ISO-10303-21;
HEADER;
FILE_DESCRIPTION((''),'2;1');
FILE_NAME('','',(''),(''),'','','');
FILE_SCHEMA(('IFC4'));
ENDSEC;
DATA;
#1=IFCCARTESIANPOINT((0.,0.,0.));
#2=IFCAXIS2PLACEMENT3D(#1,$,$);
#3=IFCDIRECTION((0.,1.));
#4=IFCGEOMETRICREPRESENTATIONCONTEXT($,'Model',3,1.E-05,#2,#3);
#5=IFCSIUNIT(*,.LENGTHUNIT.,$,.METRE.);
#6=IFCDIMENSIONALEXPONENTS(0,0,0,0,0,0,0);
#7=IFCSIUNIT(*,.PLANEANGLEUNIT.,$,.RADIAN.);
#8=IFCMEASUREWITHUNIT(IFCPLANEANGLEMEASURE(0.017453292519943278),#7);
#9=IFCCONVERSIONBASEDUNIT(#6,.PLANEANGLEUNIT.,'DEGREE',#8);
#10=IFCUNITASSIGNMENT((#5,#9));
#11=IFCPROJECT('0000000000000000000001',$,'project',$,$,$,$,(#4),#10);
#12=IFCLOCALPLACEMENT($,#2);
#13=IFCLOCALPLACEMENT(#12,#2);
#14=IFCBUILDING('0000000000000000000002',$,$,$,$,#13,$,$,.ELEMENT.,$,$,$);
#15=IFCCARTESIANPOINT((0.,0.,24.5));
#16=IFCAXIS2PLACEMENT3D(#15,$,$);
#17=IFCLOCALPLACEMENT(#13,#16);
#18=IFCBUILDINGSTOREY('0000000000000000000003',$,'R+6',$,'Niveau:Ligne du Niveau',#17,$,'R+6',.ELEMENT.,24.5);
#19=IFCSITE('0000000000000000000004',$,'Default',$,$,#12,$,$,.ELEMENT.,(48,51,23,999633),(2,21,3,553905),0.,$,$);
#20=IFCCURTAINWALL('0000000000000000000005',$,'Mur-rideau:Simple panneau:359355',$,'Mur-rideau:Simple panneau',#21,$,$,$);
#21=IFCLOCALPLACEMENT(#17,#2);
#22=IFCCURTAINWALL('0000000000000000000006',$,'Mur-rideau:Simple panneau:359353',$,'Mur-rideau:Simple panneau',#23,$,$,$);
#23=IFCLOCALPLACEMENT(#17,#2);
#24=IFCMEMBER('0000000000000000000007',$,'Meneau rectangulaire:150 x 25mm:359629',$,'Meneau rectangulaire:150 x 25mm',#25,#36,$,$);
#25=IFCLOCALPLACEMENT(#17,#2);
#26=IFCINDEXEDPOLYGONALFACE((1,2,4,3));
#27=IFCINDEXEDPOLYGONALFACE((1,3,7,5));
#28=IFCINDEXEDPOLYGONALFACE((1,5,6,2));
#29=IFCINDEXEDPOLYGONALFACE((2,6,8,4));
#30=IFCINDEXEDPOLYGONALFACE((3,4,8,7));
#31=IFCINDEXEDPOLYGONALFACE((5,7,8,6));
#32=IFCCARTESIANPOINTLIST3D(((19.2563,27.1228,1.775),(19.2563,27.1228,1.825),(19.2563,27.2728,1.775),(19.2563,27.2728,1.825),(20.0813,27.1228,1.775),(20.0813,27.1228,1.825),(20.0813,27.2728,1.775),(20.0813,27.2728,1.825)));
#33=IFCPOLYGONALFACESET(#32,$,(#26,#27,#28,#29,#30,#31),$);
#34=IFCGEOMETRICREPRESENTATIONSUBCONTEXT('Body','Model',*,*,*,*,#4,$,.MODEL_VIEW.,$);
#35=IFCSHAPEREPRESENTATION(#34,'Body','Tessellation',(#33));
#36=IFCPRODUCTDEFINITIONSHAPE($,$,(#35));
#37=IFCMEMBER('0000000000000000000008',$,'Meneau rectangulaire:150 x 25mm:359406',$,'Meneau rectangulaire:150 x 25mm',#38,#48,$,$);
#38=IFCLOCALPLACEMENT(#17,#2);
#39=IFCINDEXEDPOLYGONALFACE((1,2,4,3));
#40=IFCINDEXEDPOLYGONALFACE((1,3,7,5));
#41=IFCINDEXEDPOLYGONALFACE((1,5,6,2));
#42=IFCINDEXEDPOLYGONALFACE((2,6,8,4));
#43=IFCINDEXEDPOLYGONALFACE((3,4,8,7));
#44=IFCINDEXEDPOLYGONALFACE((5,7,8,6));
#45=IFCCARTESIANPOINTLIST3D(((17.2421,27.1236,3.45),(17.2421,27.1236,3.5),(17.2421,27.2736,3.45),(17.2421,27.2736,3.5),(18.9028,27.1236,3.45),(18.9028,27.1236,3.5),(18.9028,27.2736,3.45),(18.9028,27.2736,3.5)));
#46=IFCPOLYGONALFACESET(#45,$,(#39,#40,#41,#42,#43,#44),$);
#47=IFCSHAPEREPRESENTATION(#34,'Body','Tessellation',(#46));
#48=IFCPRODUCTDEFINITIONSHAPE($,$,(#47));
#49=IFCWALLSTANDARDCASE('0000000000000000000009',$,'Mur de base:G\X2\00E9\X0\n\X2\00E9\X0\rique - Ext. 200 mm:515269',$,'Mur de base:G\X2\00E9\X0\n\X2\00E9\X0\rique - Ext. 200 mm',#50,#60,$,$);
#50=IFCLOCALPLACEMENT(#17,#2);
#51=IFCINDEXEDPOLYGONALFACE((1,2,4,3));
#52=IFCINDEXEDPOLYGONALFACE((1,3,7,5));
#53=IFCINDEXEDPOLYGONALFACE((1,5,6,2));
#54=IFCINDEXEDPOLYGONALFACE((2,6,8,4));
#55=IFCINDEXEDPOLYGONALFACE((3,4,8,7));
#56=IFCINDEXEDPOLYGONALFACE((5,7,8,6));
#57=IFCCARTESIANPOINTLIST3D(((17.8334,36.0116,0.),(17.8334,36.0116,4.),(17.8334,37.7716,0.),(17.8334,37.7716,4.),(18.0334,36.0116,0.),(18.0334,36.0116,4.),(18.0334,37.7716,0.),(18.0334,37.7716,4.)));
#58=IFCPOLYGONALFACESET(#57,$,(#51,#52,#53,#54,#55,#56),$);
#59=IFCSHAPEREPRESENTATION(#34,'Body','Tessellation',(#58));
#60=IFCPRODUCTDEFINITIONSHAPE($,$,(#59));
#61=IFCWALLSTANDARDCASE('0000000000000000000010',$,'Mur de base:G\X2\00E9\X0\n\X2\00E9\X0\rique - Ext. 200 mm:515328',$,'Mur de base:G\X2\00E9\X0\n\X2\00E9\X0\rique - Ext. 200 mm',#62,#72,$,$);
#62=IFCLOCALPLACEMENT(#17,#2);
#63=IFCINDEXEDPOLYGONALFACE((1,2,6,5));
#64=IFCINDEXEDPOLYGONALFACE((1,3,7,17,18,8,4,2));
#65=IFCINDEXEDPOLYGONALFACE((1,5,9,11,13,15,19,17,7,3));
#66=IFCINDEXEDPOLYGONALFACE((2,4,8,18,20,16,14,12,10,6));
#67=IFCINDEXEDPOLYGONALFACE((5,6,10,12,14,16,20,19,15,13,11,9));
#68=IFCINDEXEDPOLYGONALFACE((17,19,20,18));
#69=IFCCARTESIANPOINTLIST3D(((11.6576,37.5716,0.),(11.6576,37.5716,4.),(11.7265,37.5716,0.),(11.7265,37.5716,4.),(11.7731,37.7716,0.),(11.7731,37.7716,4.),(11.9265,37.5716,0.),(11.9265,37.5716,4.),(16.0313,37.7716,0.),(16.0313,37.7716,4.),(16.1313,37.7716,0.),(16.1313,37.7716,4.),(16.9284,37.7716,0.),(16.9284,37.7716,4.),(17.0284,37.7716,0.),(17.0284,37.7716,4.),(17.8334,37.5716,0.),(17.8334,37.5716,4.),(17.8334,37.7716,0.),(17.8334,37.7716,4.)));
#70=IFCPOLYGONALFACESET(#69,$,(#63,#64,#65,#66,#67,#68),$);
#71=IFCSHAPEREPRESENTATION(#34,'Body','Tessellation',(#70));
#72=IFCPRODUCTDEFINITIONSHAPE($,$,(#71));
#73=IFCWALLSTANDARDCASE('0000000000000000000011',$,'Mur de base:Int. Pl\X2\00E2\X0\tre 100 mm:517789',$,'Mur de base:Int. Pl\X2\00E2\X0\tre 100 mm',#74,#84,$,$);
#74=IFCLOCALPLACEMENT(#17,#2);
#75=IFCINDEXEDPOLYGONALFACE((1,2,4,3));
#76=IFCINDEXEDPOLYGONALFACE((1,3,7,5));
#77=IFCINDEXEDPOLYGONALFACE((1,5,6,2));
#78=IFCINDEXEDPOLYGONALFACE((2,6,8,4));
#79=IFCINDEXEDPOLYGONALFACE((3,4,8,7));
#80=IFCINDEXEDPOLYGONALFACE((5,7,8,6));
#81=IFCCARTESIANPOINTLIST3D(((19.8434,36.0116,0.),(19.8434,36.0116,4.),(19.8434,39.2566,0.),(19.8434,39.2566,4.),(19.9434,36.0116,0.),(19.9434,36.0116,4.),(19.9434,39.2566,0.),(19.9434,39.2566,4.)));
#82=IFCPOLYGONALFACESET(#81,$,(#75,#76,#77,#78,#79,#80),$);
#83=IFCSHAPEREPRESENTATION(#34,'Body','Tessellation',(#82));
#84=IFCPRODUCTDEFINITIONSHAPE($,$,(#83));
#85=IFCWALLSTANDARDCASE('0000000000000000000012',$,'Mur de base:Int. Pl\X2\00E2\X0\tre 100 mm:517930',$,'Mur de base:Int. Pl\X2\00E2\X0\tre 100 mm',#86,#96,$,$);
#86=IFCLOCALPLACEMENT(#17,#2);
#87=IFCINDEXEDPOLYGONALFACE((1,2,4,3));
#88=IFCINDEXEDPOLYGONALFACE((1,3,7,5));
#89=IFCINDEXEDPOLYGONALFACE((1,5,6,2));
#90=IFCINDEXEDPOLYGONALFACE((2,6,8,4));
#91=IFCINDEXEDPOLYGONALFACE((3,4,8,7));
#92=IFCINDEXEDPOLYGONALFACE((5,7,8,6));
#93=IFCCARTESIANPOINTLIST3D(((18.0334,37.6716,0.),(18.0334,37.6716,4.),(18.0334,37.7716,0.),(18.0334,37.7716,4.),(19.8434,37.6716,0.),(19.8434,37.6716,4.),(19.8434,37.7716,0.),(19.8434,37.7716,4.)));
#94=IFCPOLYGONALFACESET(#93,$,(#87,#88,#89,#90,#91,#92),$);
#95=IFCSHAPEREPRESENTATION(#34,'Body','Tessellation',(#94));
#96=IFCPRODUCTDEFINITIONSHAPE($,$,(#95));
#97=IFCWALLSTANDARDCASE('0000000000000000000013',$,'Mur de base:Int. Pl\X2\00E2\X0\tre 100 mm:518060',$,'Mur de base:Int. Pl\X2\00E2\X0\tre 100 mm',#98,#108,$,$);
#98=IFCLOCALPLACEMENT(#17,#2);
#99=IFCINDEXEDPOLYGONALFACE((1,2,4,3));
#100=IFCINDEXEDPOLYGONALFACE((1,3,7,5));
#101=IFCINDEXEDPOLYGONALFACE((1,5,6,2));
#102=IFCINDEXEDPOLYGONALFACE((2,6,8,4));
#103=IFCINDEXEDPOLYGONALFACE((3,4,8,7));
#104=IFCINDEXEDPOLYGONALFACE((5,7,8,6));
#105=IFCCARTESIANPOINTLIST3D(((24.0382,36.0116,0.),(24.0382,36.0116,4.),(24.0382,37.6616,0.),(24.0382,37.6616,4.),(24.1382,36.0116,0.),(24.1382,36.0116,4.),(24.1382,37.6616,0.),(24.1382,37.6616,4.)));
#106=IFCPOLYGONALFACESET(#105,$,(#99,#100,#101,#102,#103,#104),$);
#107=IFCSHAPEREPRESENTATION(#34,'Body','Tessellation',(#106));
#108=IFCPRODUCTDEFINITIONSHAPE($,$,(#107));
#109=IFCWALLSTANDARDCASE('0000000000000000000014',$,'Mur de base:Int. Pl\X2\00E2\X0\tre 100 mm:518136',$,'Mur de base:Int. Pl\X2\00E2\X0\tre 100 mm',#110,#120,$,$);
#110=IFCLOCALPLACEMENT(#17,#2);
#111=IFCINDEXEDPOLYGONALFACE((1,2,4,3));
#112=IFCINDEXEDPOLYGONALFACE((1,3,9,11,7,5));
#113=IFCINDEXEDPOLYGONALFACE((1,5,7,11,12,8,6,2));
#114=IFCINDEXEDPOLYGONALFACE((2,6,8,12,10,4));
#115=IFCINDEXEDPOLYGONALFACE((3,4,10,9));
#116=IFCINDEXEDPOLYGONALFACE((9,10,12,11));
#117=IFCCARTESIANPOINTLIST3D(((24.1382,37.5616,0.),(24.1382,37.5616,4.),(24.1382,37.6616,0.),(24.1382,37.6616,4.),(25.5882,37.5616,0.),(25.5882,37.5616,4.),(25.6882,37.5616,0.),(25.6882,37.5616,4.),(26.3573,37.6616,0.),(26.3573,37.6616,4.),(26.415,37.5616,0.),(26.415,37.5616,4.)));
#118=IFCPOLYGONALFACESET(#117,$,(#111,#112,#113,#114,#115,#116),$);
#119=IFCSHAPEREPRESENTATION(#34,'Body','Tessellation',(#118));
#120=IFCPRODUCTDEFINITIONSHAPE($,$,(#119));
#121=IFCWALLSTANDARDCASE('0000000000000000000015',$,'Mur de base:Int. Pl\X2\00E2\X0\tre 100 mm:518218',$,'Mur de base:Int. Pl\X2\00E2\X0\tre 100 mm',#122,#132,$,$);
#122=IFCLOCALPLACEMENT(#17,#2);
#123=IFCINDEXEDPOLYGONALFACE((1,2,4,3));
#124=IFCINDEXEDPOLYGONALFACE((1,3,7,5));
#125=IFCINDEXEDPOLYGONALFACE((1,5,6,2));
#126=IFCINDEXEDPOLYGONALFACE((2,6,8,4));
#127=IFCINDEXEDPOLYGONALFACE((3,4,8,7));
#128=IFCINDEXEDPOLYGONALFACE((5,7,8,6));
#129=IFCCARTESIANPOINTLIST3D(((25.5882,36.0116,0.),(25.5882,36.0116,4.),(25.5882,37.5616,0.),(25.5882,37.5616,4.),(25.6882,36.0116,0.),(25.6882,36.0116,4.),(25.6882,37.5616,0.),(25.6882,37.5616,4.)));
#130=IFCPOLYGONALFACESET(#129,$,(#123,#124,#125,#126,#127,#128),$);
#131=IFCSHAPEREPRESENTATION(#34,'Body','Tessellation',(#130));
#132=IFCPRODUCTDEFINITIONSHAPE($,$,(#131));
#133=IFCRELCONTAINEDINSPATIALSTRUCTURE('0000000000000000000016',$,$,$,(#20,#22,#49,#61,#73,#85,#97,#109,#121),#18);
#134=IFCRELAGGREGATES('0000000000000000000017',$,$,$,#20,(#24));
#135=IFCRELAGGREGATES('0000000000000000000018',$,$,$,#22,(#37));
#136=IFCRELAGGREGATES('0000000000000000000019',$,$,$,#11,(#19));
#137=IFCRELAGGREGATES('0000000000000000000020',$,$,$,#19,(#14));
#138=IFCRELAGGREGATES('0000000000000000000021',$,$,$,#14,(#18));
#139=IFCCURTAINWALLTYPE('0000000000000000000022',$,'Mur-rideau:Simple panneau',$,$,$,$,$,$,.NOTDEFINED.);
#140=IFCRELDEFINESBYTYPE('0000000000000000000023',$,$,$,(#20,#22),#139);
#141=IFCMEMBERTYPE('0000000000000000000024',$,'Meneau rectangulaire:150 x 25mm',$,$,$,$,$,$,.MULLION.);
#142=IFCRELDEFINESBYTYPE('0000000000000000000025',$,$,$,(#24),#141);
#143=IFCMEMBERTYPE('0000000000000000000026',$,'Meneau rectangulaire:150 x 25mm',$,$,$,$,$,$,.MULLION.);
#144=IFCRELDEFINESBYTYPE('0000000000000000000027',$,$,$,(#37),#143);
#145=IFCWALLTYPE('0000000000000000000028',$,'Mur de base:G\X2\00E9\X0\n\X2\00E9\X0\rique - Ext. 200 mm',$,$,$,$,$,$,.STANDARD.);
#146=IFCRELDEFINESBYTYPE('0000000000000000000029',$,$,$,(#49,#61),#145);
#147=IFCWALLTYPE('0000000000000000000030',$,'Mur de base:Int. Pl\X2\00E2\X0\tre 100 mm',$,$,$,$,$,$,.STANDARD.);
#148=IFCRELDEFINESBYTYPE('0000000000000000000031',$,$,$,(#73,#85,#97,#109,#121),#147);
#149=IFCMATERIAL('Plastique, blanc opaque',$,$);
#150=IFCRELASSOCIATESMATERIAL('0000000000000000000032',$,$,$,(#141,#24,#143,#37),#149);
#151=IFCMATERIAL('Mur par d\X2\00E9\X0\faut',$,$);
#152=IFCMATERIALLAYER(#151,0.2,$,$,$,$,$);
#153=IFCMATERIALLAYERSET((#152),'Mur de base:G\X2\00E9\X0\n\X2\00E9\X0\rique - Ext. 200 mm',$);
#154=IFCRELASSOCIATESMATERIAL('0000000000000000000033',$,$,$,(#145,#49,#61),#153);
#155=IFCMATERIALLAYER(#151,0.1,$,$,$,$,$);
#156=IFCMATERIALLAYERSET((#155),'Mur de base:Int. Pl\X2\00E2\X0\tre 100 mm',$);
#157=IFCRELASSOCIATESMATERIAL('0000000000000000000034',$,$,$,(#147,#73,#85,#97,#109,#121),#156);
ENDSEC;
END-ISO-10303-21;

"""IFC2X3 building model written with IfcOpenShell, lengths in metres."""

from ifc_helpers import new_model, entity, si_unit, converted_unit, direction, frame, frame_2d, origin, origin_2d_with_axis, place, context, subcontext, project, spatial, polyline, rectangle, outline, extrude, source, transform, mapped, material, layer, layer_set, layer_usage, type_object, type_shapes, element, aggregate, save


model = new_model("IFC2X3")

# Units and contexts
model_context = context("Model", 3, precision=1e-05, world=origin(), true_north=direction((0.0, 1.0)))
body_context = subcontext(model_context, "Body", "Model", "MODEL_VIEW")
ifc_project = project(units=[si_unit("LENGTHUNIT", "METRE"), converted_unit("PLANEANGLEUNIT", "DEGREE", entity("IfcPlaneAngleMeasure", 0.017453292519943278), si_unit("PLANEANGLEUNIT", "RADIAN"), dimensions=[0, 0, 0, 0, 0, 0, 0])], contexts=[model_context])

# Site, building, storey
site_placement = place(None, origin())
site = spatial("IfcSite", under=ifc_project, at=site_placement, Name="Default", CompositionType="ELEMENT", RefLatitude=(48, 51, 23, 999633), RefLongitude=(2, 21, 3, 553905), RefElevation=0.0)
building_placement = place(site_placement, origin())
building = spatial("IfcBuilding", under=site, at=building_placement, CompositionType="ELEMENT")
storey_placement = place(building_placement, frame((0.0, 0.0, 24.5)))
storey = spatial("IfcBuildingStorey", under=building, at=storey_placement, Name="R+6", ObjectType="Niveau:Ligne du Niveau", LongName="R+6", CompositionType="ELEMENT", Elevation=24.5)

# Curtain wall
curtain_wall_type = type_object("IfcCurtainWallType", Name="Mur-rideau:Simple panneau", PredefinedType="NOTDEFINED")
curtain_wall_1_placement = place(storey_placement, frame((0.0, 0.0, -24.5)))
curtain_wall_1 = element("IfcCurtainWall", 1, at=curtain_wall_1_placement, inside=storey, type_object=curtain_wall_type, Name="Mur-rideau:Simple panneau:359355", ObjectType="Mur-rideau:Simple panneau")
ifc_material_1 = material(Name="Plastique, blanc opaque")

# Curtain wall
curtain_wall_2_placement = place(storey_placement, frame((0.0, 0.0, -24.5)))
curtain_wall_2 = element("IfcCurtainWall", 2, at=curtain_wall_2_placement, inside=storey, type_object=curtain_wall_type, Name="Mur-rideau:Simple panneau:359353", ObjectType="Mur-rideau:Simple panneau")

# Members
member_type_1 = type_object("IfcMemberType", Name="Meneau rectangulaire:150 x 25mm", PredefinedType="MULLION", material=ifc_material_1)
shared_shape_1 = source(origin(), body_context, "Body", "SweptSolid", [
    extrude(rectangle(XDim=0.05, YDim=0.15, at=frame_2d((0.0, 0.0), x_axis=(1.0, 0.0))), frame((0.0, 0.0, -0.825), z_axis=(0.0, 0.0, 1.0), x_axis=(-1.0, 0.0, 0.0)), (0.0, 0.0, 1.0), 0.825),
])
type_shapes(member_type_1, [shared_shape_1])
member_1_placement = place(curtain_wall_1_placement, frame((20.0813, 27.1978, 26.3), z_axis=(1.0, 0.0, 0.0), x_axis=(0.0, 0.0, 1.0)))
member_1 = element("IfcMember", 3, at=member_1_placement, type_object=member_type_1, material=ifc_material_1, Name="Meneau rectangulaire:150 x 25mm:359629", ObjectType="Meneau rectangulaire:150 x 25mm", context=body_context, shape_type="MappedRepresentation", body=[
    mapped(shared_shape_1, transform((0.0, 0.0, 0.0), scale=1.0)),
])
member_type_2 = type_object("IfcMemberType", Name="Meneau rectangulaire:150 x 25mm", PredefinedType="MULLION", material=ifc_material_1)
shared_shape_2 = source(origin(), body_context, "Body", "SweptSolid", [
    extrude(rectangle(XDim=0.05, YDim=0.15, at=origin_2d_with_axis()), frame((-0.025, 0.0, -1.6607), z_axis=(0.0, 0.0, 1.0), x_axis=(-1.0, 0.0, 0.0)), (0.0, 0.0, 1.0), 1.6607),
])
type_shapes(member_type_2, [shared_shape_2])
member_2_placement = place(curtain_wall_2_placement, frame((18.9028, 27.1986, 28.0), z_axis=(1.0, 0.0, 0.0), x_axis=(0.0, 0.0, 1.0)))
member_2 = element("IfcMember", 4, at=member_2_placement, type_object=member_type_2, material=ifc_material_1, Name="Meneau rectangulaire:150 x 25mm:359406", ObjectType="Meneau rectangulaire:150 x 25mm", context=body_context, shape_type="MappedRepresentation", body=[
    mapped(shared_shape_2, transform((0.0, 0.0, 0.0), scale=1.0)),
])

aggregate(curtain_wall_1, [member_1])
aggregate(curtain_wall_2, [member_2])

# Walls
ifc_material_2 = material(Name="Mur par défaut")
ifc_layer_1 = layer(ifc_material_2, 0.2)
ifc_layer_set_1 = layer_set([ifc_layer_1], Name="Mur de base:Générique - Ext. 200 mm")
ifc_layer_usage_1 = layer_usage(ifc_layer_set_1, "AXIS2", "NEGATIVE", 0.1)
wall_type_1 = type_object("IfcWallType", Name="Mur de base:Générique - Ext. 200 mm", PredefinedType="STANDARD", material=ifc_layer_set_1)
wall_1_placement = place(storey_placement, frame((17.9334, 36.0116, 0.0), z_axis=(0.0, 0.0, 1.0), x_axis=(0.0, 1.0, 0.0)))
element("IfcWallStandardCase", 5, at=wall_1_placement, inside=storey, type_object=wall_type_1, material=ifc_layer_usage_1, Name="Mur de base:Générique - Ext. 200 mm:515269", ObjectType="Mur de base:Générique - Ext. 200 mm", context=body_context, shape_type="SweptSolid", body=[
    extrude(rectangle(XDim=1.76, YDim=0.2, at=frame_2d((0.88, 0.0), x_axis=(-1.0, 0.0))), origin(), (0.0, 0.0, 1.0), 4.0),
])
ifc_layer_usage_2 = layer_usage(ifc_layer_set_1, "AXIS2", "NEGATIVE", 0.1)
wall_2_placement = place(storey_placement, frame((17.8334, 37.6716, 0.0), z_axis=(0.0, 0.0, 1.0), x_axis=(-1.0, 0.0, 0.0)))
element("IfcWallStandardCase", 6, at=wall_2_placement, inside=storey, type_object=wall_type_1, material=ifc_layer_usage_2, Name="Mur de base:Générique - Ext. 200 mm:515328", ObjectType="Mur de base:Générique - Ext. 200 mm", context=body_context, shape_type="SweptSolid", body=[
    extrude(outline(polyline([(6.0604, -0.1), (6.1758, 0.1), (6.1069, 0.1), (5.9069, 0.1), (0.0, 0.1), (0.0, -0.1), (0.805, -0.1), (0.905, -0.1), (1.7022, -0.1), (1.8022, -0.1), (6.0604, -0.1)])), origin(), (0.0, 0.0, 1.0), 4.0),
])
ifc_layer_2 = layer(ifc_material_2, 0.1)
ifc_layer_set_2 = layer_set([ifc_layer_2], Name="Mur de base:Int. Plâtre 100 mm")
ifc_layer_usage_3 = layer_usage(ifc_layer_set_2, "AXIS2", "NEGATIVE", 0.05)
wall_type_2 = type_object("IfcWallType", Name="Mur de base:Int. Plâtre 100 mm", PredefinedType="STANDARD", material=ifc_layer_set_2)
wall_3_placement = place(storey_placement, frame((19.8934, 36.0116, 0.0), z_axis=(0.0, 0.0, 1.0), x_axis=(0.0, 1.0, 0.0)))
element("IfcWallStandardCase", 7, at=wall_3_placement, inside=storey, type_object=wall_type_2, material=ifc_layer_usage_3, Name="Mur de base:Int. Plâtre 100 mm:517789", ObjectType="Mur de base:Int. Plâtre 100 mm", context=body_context, shape_type="SweptSolid", body=[
    extrude(rectangle(XDim=3.245, YDim=0.1, at=frame_2d((1.6225, 0.0), x_axis=(-1.0, 0.0))), origin(), (0.0, 0.0, 1.0), 4.0),
])
ifc_layer_usage_4 = layer_usage(ifc_layer_set_2, "AXIS2", "NEGATIVE", 0.05)
wall_4_placement = place(storey_placement, frame((19.8434, 37.7216, 0.0), z_axis=(0.0, 0.0, 1.0), x_axis=(-1.0, 0.0, 0.0)))
element("IfcWallStandardCase", 8, at=wall_4_placement, inside=storey, type_object=wall_type_2, material=ifc_layer_usage_4, Name="Mur de base:Int. Plâtre 100 mm:517930", ObjectType="Mur de base:Int. Plâtre 100 mm", context=body_context, shape_type="SweptSolid", body=[
    extrude(rectangle(XDim=1.81, YDim=0.1, at=frame_2d((0.905, 0.0), x_axis=(-1.0, 0.0))), origin(), (0.0, 0.0, 1.0), 4.0),
])
ifc_layer_usage_5 = layer_usage(ifc_layer_set_2, "AXIS2", "NEGATIVE", 0.05)
wall_5_placement = place(storey_placement, frame((24.0882, 36.0116, 0.0), z_axis=(0.0, 0.0, 1.0), x_axis=(0.0, 1.0, 0.0)))
element("IfcWallStandardCase", 9, at=wall_5_placement, inside=storey, type_object=wall_type_2, material=ifc_layer_usage_5, Name="Mur de base:Int. Plâtre 100 mm:518060", ObjectType="Mur de base:Int. Plâtre 100 mm", context=body_context, shape_type="SweptSolid", body=[
    extrude(rectangle(XDim=1.65, YDim=0.1, at=frame_2d((0.825, 0.0), x_axis=(-1.0, 0.0))), origin(), (0.0, 0.0, 1.0), 4.0),
])
ifc_layer_usage_6 = layer_usage(ifc_layer_set_2, "AXIS2", "NEGATIVE", 0.05)
wall_6_placement = place(storey_placement, frame((24.1382, 37.6116, 0.0)))
element("IfcWallStandardCase", 10, at=wall_6_placement, inside=storey, type_object=wall_type_2, material=ifc_layer_usage_6, Name="Mur de base:Int. Plâtre 100 mm:518136", ObjectType="Mur de base:Int. Plâtre 100 mm", context=body_context, shape_type="SweptSolid", body=[
    extrude(outline(polyline([(2.2768, -0.05), (2.219, 0.05), (0.0, 0.05), (0.0, -0.05), (1.45, -0.05), (1.55, -0.05), (2.2768, -0.05)])), origin(), (0.0, 0.0, 1.0), 4.0),
])
ifc_layer_usage_7 = layer_usage(ifc_layer_set_2, "AXIS2", "NEGATIVE", 0.05)
wall_7_placement = place(storey_placement, frame((25.6382, 37.5616, 0.0), z_axis=(0.0, 0.0, 1.0), x_axis=(0.0, -1.0, 0.0)))
element("IfcWallStandardCase", 11, at=wall_7_placement, inside=storey, type_object=wall_type_2, material=ifc_layer_usage_7, Name="Mur de base:Int. Plâtre 100 mm:518218", ObjectType="Mur de base:Int. Plâtre 100 mm", context=body_context, shape_type="SweptSolid", body=[
    extrude(rectangle(XDim=1.55, YDim=0.1, at=frame_2d((0.775, 0.0), x_axis=(-1.0, 0.0))), origin(), (0.0, 0.0, 1.0), 4.0),
])

save(model, "model.ifc")
